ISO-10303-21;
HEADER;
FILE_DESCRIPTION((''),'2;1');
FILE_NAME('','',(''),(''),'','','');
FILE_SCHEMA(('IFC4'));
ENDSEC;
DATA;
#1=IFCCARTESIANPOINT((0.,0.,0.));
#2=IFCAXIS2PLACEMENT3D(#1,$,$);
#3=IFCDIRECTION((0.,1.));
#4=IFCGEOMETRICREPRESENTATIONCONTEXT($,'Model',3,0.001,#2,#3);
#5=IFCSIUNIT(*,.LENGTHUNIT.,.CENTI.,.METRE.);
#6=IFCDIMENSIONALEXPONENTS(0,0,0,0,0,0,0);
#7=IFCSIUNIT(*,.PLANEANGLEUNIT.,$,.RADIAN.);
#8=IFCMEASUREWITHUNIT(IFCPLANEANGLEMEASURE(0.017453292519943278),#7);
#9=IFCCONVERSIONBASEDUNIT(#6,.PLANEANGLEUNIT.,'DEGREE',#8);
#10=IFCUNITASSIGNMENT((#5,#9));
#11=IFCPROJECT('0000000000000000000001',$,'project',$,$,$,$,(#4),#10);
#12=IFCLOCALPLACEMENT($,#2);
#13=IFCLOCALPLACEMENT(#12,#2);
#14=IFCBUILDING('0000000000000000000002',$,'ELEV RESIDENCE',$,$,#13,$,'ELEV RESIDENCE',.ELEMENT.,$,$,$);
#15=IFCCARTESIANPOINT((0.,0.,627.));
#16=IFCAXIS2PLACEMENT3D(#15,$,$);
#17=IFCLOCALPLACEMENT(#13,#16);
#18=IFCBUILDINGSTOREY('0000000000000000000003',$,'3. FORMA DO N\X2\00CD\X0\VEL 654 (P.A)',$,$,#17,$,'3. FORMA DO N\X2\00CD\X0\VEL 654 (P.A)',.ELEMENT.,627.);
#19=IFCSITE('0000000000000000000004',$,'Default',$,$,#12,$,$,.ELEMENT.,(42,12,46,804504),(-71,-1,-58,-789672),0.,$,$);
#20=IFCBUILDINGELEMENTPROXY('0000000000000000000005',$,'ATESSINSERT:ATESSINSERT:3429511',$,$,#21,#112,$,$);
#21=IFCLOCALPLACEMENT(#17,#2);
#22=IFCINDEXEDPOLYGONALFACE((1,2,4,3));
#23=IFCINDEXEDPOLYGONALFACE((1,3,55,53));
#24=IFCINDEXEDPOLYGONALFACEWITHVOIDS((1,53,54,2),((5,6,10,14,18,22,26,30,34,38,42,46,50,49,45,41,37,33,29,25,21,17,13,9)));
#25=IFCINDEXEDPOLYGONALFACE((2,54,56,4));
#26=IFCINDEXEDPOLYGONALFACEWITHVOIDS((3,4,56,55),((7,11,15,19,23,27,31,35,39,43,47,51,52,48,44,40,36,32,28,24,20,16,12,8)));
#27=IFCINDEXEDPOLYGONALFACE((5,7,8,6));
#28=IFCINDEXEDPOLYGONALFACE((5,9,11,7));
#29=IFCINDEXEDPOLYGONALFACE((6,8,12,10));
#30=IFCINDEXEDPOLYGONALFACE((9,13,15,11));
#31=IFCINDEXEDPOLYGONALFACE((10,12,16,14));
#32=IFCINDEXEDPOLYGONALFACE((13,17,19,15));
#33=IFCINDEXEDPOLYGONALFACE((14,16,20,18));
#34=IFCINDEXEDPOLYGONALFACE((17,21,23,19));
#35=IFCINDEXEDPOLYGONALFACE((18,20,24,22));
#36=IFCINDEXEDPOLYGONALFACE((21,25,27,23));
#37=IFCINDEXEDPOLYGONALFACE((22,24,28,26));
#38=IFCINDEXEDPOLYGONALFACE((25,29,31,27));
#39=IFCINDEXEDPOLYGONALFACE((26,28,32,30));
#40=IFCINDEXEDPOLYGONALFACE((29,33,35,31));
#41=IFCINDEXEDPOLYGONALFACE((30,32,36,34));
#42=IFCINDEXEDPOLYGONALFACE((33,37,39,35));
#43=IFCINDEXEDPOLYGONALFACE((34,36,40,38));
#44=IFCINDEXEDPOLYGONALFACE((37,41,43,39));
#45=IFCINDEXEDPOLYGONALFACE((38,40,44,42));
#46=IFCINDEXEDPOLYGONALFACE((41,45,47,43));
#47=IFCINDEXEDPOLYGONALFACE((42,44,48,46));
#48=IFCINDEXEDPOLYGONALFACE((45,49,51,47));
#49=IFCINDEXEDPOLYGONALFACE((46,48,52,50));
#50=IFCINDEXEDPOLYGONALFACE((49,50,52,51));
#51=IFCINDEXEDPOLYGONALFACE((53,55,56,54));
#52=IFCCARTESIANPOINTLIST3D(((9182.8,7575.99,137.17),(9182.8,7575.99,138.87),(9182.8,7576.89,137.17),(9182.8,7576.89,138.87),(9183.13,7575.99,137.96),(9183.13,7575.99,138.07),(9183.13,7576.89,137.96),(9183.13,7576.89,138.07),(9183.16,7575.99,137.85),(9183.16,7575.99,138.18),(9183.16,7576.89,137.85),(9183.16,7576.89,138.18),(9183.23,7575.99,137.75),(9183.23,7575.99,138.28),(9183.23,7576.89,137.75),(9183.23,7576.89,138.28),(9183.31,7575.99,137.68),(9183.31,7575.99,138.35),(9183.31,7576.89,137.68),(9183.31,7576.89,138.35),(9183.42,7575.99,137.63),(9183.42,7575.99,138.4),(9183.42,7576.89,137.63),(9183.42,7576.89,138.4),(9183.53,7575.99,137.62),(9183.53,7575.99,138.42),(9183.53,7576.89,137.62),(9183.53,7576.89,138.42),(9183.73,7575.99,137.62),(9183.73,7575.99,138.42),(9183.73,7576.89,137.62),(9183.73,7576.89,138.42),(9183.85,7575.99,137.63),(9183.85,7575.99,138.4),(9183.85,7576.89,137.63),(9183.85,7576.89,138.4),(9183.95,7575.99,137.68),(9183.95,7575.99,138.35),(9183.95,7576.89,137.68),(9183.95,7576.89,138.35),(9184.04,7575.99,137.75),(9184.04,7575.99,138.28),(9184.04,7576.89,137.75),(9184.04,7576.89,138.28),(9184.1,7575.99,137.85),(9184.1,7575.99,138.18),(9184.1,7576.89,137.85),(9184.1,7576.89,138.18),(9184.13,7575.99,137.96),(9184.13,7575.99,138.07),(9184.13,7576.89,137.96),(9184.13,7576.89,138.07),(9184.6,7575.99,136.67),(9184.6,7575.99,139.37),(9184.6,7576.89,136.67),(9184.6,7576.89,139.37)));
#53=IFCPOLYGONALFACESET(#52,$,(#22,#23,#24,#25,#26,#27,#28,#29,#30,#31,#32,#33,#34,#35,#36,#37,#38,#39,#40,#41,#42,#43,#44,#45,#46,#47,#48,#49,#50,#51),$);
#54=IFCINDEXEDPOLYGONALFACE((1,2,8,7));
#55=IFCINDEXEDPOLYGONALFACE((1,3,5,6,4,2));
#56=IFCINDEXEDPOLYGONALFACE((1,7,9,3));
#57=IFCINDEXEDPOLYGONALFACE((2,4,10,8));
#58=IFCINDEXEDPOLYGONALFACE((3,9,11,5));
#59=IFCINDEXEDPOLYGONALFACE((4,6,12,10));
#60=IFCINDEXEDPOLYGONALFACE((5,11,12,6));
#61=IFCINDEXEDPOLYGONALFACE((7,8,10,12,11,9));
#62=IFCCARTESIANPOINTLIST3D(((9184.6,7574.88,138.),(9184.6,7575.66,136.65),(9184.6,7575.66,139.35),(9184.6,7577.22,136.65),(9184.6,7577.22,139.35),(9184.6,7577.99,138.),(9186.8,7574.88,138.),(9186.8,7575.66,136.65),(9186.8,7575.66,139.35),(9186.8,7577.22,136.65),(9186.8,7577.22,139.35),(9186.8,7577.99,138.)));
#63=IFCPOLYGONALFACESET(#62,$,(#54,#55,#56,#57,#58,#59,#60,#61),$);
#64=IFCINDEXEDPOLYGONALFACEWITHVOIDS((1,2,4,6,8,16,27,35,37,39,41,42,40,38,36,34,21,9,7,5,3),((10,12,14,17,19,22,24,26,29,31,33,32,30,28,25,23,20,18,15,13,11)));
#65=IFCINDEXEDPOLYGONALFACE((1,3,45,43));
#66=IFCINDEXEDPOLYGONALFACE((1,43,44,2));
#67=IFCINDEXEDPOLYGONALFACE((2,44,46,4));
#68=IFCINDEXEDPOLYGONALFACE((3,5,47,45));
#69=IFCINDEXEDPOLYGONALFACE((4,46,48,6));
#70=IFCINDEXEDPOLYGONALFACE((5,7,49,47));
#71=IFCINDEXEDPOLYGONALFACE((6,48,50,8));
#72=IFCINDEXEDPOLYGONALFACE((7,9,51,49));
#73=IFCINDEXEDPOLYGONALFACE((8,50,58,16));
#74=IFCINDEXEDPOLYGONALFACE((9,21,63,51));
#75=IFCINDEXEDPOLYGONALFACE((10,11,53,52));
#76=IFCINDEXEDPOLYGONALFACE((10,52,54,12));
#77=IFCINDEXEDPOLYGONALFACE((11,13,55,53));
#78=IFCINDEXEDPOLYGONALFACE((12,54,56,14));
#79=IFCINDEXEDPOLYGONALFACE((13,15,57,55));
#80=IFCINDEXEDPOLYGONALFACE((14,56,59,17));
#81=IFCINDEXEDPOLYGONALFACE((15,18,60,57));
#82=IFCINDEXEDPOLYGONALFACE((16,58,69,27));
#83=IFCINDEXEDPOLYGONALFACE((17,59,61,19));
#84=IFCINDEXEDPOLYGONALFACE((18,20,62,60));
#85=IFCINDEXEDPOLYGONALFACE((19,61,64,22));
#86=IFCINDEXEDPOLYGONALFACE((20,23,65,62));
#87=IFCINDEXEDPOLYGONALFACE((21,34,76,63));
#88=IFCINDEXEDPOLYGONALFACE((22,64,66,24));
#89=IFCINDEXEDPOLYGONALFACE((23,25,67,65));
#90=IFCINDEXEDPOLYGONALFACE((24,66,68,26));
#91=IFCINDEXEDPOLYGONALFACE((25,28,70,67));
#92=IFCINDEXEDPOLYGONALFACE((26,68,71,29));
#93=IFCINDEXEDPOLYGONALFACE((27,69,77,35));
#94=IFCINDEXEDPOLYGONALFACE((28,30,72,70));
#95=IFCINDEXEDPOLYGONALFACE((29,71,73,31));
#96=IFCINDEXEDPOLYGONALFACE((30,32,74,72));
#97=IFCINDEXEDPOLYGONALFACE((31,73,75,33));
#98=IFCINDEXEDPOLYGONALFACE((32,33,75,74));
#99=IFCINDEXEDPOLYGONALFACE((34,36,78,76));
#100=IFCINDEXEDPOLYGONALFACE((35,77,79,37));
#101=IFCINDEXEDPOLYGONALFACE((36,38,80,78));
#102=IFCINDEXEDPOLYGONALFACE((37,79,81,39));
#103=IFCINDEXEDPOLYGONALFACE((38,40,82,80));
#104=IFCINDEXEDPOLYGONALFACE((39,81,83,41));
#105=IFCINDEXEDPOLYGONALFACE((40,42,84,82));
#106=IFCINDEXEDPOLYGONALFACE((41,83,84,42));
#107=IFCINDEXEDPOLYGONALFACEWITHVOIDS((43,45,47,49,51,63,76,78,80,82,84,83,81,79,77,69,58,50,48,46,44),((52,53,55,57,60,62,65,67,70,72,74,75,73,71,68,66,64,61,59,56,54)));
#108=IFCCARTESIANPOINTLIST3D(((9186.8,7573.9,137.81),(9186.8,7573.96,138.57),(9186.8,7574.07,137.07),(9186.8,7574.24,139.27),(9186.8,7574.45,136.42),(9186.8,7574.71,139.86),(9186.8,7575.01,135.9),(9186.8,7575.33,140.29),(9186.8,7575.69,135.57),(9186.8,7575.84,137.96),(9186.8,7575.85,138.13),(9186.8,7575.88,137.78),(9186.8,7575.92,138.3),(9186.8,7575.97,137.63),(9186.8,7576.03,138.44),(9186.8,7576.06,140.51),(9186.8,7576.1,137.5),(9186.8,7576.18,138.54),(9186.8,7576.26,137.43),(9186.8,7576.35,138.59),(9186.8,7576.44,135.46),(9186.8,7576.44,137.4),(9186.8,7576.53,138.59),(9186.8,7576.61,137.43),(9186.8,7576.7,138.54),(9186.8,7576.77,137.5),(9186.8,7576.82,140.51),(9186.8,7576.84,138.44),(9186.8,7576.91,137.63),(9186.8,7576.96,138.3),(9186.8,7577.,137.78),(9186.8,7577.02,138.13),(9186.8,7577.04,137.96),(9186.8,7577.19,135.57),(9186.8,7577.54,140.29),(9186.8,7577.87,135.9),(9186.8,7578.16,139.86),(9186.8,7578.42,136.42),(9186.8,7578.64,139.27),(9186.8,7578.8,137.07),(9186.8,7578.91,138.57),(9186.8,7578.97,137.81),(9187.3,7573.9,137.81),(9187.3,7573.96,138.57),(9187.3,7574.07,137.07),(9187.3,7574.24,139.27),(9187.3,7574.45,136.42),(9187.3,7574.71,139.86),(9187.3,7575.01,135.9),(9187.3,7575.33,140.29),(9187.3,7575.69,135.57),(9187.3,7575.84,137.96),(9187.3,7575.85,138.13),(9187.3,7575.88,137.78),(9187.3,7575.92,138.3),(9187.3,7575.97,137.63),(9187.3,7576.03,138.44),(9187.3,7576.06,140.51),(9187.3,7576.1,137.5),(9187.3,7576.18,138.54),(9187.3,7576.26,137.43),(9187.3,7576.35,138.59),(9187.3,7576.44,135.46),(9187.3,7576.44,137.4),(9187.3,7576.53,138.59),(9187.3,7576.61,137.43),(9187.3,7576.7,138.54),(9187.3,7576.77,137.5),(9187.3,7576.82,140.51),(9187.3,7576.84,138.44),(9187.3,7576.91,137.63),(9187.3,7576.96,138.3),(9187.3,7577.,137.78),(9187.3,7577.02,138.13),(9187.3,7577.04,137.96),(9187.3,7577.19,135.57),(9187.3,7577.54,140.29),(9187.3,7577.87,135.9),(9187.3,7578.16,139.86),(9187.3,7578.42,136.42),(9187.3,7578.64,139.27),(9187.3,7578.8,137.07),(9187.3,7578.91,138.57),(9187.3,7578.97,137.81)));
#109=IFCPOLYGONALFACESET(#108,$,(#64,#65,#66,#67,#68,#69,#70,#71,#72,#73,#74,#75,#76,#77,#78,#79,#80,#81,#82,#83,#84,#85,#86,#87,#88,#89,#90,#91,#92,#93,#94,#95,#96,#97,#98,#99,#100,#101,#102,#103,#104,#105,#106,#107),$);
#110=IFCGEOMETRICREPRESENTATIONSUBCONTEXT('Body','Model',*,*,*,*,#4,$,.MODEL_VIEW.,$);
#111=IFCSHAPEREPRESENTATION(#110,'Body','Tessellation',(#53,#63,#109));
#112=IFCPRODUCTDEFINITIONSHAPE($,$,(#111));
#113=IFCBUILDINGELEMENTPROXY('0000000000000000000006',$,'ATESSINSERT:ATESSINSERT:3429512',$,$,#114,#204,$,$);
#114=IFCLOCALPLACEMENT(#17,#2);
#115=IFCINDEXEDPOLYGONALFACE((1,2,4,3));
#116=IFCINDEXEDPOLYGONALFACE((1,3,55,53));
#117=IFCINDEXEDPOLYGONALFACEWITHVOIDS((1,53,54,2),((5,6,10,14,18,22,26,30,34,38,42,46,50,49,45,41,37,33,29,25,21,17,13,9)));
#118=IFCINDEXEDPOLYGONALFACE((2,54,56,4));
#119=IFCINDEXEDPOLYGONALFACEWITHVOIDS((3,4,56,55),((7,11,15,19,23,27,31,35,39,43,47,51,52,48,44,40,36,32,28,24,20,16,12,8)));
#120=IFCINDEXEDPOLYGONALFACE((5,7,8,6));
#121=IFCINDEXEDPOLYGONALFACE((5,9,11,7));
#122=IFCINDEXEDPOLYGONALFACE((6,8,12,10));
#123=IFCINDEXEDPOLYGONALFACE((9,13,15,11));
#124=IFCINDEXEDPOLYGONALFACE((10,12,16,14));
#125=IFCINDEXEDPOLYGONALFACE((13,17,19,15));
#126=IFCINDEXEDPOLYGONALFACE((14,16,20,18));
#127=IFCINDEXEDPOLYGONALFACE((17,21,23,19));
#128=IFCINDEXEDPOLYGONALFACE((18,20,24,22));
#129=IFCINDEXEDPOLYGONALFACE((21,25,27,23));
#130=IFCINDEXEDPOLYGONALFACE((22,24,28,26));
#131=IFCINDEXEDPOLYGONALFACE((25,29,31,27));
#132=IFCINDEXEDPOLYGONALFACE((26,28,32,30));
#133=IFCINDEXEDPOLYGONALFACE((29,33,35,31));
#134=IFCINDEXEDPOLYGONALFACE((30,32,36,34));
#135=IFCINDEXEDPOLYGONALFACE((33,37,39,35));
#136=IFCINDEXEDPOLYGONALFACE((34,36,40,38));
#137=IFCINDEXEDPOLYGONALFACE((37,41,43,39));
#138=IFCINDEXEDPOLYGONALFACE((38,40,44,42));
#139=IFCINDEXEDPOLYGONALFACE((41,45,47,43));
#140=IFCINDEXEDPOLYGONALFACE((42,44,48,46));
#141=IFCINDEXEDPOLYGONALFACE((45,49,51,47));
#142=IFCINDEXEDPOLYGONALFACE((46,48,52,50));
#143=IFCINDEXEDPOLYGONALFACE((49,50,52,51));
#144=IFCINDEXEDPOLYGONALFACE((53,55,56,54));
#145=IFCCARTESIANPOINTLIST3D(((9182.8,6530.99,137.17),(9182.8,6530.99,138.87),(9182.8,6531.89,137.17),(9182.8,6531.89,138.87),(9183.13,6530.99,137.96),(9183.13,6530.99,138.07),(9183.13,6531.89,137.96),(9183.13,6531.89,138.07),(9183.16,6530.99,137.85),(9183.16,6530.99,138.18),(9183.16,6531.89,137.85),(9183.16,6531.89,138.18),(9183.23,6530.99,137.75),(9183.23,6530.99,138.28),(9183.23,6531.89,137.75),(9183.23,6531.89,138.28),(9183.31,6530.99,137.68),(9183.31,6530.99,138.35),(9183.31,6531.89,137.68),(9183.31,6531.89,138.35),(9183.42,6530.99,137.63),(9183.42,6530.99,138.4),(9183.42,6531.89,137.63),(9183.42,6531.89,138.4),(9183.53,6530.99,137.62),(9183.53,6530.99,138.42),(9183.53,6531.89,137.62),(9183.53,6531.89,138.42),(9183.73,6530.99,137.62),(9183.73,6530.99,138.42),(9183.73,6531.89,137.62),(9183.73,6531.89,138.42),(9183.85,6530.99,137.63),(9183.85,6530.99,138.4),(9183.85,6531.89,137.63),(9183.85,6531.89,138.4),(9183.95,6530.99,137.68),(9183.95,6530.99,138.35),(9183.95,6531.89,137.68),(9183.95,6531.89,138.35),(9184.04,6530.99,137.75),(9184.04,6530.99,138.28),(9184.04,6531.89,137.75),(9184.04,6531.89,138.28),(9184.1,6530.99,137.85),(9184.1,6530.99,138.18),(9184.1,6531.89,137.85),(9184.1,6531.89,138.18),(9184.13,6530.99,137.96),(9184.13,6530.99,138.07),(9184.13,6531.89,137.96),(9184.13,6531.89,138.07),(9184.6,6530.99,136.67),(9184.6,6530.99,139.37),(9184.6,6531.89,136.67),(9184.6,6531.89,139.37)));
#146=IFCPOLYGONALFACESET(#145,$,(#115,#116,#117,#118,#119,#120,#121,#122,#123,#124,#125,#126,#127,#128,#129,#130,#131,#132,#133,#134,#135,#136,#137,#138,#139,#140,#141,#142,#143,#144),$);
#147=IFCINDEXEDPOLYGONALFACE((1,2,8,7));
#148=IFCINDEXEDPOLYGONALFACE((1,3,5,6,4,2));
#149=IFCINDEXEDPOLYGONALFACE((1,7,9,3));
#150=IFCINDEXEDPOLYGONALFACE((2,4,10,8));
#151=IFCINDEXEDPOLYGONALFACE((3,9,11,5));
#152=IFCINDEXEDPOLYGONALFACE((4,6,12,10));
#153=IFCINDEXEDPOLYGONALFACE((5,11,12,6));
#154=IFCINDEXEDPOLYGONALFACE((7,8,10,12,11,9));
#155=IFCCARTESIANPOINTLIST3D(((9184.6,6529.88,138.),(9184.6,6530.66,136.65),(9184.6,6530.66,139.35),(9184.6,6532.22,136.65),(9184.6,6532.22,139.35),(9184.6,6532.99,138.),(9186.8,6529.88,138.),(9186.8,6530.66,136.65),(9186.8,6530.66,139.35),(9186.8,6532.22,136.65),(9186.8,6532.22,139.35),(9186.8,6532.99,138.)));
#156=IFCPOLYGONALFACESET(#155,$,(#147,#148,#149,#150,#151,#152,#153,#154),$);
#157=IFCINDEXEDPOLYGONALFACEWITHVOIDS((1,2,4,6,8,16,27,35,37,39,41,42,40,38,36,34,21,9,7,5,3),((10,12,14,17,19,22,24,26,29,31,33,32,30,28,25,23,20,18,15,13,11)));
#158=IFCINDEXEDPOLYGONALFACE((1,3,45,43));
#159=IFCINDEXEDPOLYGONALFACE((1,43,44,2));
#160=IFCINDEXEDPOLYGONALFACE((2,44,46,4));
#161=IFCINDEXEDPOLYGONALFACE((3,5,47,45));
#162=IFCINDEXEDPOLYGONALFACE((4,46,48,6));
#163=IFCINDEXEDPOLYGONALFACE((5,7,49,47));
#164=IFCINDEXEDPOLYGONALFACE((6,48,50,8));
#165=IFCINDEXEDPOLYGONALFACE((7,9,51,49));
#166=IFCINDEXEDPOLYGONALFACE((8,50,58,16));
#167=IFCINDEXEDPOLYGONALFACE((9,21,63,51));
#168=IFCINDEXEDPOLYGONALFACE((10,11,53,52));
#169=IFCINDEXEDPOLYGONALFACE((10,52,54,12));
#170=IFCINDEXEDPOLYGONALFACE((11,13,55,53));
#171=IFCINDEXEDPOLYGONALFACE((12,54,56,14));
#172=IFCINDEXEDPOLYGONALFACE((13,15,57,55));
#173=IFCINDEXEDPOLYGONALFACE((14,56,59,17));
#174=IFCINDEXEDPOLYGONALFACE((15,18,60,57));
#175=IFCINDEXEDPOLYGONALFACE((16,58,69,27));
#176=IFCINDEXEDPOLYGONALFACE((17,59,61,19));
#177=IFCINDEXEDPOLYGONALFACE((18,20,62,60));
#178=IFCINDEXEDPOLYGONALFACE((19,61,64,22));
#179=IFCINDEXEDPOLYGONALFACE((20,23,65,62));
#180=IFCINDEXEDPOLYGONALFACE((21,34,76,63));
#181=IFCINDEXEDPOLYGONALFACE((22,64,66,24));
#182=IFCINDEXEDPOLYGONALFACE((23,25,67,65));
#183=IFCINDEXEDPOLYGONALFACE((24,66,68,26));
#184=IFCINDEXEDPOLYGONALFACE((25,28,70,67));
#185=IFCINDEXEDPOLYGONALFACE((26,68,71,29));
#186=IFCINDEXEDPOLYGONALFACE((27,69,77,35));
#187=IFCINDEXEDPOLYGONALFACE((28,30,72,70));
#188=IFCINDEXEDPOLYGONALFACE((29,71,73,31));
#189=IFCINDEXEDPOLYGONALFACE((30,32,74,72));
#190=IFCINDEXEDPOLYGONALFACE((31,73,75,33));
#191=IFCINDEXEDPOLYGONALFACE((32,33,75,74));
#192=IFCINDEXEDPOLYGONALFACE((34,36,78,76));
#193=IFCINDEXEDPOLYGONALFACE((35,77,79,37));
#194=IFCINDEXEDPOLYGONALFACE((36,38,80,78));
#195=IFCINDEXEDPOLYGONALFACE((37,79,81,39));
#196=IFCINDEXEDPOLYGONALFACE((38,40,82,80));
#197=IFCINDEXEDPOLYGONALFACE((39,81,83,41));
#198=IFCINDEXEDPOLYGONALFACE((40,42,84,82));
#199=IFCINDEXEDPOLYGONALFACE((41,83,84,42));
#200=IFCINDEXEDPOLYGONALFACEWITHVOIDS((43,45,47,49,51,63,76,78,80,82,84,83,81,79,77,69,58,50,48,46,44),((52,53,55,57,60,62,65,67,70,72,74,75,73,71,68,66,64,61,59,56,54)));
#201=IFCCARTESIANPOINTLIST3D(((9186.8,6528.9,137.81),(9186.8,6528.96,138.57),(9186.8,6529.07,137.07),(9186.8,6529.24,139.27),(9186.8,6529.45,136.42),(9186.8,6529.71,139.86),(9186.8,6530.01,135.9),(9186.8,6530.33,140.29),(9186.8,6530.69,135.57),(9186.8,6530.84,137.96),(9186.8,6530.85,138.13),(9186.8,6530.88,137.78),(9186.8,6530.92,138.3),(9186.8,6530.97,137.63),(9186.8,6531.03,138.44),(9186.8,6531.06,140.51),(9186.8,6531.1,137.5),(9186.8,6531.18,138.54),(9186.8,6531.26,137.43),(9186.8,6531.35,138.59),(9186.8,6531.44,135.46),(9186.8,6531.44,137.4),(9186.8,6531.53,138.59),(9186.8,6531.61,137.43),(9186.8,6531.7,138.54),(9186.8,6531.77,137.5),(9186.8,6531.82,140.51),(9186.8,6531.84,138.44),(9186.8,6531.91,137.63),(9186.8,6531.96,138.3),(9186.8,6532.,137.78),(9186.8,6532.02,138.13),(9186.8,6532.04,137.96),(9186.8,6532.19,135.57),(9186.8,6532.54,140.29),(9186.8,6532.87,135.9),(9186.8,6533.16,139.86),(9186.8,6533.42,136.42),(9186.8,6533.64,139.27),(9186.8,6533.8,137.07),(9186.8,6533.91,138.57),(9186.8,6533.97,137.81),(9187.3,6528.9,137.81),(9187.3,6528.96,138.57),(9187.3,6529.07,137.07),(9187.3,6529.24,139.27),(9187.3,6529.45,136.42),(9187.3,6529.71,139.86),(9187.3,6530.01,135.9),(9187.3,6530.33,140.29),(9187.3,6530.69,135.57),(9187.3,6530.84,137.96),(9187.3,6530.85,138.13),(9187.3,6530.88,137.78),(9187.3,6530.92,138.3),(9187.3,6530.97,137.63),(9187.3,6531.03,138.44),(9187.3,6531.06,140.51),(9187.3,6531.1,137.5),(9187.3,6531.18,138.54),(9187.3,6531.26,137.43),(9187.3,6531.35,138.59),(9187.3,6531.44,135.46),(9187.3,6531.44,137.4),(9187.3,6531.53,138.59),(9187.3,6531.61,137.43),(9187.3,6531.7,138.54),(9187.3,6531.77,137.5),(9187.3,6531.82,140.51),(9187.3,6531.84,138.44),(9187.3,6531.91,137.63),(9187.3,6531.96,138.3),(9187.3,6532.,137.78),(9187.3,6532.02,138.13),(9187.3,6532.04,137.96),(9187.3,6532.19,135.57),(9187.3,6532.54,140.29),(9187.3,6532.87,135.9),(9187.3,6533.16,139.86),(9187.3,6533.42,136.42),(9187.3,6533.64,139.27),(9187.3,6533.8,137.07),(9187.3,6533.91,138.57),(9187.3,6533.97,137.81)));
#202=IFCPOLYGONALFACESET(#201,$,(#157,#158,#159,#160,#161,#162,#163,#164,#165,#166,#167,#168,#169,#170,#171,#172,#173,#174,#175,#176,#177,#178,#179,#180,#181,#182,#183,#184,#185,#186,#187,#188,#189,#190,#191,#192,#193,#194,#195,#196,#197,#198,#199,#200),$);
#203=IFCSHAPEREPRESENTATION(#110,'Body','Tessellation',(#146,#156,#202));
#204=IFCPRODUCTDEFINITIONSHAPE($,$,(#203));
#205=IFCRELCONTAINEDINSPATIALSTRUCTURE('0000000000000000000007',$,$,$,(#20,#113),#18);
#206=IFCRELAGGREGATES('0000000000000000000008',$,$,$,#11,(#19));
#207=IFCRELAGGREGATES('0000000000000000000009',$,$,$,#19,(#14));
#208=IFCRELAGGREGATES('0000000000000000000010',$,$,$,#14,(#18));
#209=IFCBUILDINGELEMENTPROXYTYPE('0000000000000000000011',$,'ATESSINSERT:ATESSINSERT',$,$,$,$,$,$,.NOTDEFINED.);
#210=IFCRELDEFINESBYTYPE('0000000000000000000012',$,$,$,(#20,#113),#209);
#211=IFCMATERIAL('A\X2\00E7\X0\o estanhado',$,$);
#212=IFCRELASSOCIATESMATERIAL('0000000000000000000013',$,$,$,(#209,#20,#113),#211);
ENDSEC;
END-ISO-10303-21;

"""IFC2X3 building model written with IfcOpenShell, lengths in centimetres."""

from ifc_helpers import new_model, entity, si_unit, converted_unit, direction, frame, frame_2d, origin, place, context, subcontext, project, spatial, polyline, circle_curve, parameter, trimmed, segment, composite_curve, hollow_circle, outline, extrude, source, transform, mapped, material, type_object, type_shapes, element, save


model = new_model("IFC2X3")

# Units and contexts
model_context = context("Model", 3, precision=0.001, world=origin(), true_north=direction((0.0, 1.0)))
body_context = subcontext(model_context, "Body", "Model", "MODEL_VIEW")
ifc_project = project(units=[si_unit("LENGTHUNIT", "METRE", prefix="CENTI"), converted_unit("PLANEANGLEUNIT", "DEGREE", entity("IfcPlaneAngleMeasure", 0.017453292519943278), si_unit("PLANEANGLEUNIT", "RADIAN"), dimensions=[0, 0, 0, 0, 0, 0, 0])], contexts=[model_context])

# Site, building, storey
site_placement = place(None, origin())
site = spatial("IfcSite", under=ifc_project, at=site_placement, Name="Default", CompositionType="ELEMENT", RefLatitude=(42, 12, 46, 804504), RefLongitude=(-71, -1, -58, -789672), RefElevation=0.0)
building_placement = place(site_placement, origin())
building = spatial("IfcBuilding", under=site, at=building_placement, Name="ELEV RESIDENCE", LongName="ELEV RESIDENCE", CompositionType="ELEMENT")
storey_placement = place(building_placement, frame((0.0, 0.0, 627.0)))
storey = spatial("IfcBuildingStorey", under=building, at=storey_placement, Name="3. FORMA DO NÍVEL 654 (P.A)", LongName="3. FORMA DO NÍVEL 654 (P.A)", CompositionType="ELEMENT", Elevation=627.0)

# Building element proxies
ifc_material_1 = material(Name="Aço estanhado")
building_element_proxy_type_1 = type_object("IfcBuildingElementProxyType", Name="ATESSINSERT:ATESSINSERT", PredefinedType="NOTDEFINED", material=ifc_material_1)
shared_shape_1 = source(origin(), body_context, "Body", "SweptSolid", [
    extrude(outline(polyline([(-1.35, -0.9), (1.35, -0.9), (0.85, 0.9), (-0.85, 0.9), (-1.35, -0.9)]), holes=[composite_curve([segment(trimmed(circle_curve(frame_2d((0.0, 0.17), x_axis=(1.0, 0.0)), 0.4), [parameter(0.0)], [parameter(180.0)], True, "PARAMETER"), False, "CONTINUOUS"), segment(polyline([(0.4, 0.17), (0.4, -0.03)]), True, "CONTINUOUS"), segment(trimmed(circle_curve(frame_2d((0.0, -0.03), x_axis=(1.0, 0.0)), 0.4), [parameter(180.0)], [parameter(0.0)], True, "PARAMETER"), False, "CONTINUOUS"), segment(polyline([(-0.4, -0.03), (-0.4, 0.17)]), True, "CONTINUOUS")], self_intersect=False)]), frame((-1.4, -0.45, 30.02), z_axis=(0.0, 1.0, 0.0), x_axis=(0.0, 0.0, 1.0)), (0.0, 0.0, 1.0), 0.9),
    extrude(outline(polyline([(-0.78, -1.35), (0.78, -1.35), (1.56, 0.0), (0.78, 1.35), (-0.78, 1.35), (-1.56, 0.0), (-0.78, -1.35)])), frame((-4.5, 0.0, 30.0), z_axis=(1.0, 0.0, 0.0), x_axis=(0.0, 0.5, 0.866025)), (0.0, 0.0, 1.0), 2.2),
    extrude(hollow_circle(Radius=2.54, WallThickness=1.94, at=frame_2d((0.0, 0.0), x_axis=(1.0, 0.0))), frame((-5.0, 0.0, 30.0), z_axis=(1.0, 0.0, 0.0), x_axis=(0.0, 0.0, -1.0)), (0.0, 0.0, 1.0), 0.5),
])
type_shapes(building_element_proxy_type_1, [shared_shape_1])
for number, where, z_axis, x_axis, name in (
    (1, (9182.3, 7576.44, 108.0), (0.0, 0.0, 1.0), (-1.0, 0.0, 0.0), "ATESSINSERT:ATESSINSERT:3429511"),
    (2, (9182.3, 6531.44, 108.0), (0.0, 0.0, 1.0), (-1.0, 0.0, 0.0), "ATESSINSERT:ATESSINSERT:3429512"),
):
    element("IfcBuildingElementProxy", number, at=place(storey_placement, frame(where, z_axis=z_axis, x_axis=x_axis)), inside=storey, type_object=building_element_proxy_type_1, material=ifc_material_1, Name=name, context=body_context, shape_type="MappedRepresentation", body=[
        mapped(shared_shape_1, transform((0.0, 0.0, 0.0), scale=1.0)),
    ])

save(model, "model.ifc")
